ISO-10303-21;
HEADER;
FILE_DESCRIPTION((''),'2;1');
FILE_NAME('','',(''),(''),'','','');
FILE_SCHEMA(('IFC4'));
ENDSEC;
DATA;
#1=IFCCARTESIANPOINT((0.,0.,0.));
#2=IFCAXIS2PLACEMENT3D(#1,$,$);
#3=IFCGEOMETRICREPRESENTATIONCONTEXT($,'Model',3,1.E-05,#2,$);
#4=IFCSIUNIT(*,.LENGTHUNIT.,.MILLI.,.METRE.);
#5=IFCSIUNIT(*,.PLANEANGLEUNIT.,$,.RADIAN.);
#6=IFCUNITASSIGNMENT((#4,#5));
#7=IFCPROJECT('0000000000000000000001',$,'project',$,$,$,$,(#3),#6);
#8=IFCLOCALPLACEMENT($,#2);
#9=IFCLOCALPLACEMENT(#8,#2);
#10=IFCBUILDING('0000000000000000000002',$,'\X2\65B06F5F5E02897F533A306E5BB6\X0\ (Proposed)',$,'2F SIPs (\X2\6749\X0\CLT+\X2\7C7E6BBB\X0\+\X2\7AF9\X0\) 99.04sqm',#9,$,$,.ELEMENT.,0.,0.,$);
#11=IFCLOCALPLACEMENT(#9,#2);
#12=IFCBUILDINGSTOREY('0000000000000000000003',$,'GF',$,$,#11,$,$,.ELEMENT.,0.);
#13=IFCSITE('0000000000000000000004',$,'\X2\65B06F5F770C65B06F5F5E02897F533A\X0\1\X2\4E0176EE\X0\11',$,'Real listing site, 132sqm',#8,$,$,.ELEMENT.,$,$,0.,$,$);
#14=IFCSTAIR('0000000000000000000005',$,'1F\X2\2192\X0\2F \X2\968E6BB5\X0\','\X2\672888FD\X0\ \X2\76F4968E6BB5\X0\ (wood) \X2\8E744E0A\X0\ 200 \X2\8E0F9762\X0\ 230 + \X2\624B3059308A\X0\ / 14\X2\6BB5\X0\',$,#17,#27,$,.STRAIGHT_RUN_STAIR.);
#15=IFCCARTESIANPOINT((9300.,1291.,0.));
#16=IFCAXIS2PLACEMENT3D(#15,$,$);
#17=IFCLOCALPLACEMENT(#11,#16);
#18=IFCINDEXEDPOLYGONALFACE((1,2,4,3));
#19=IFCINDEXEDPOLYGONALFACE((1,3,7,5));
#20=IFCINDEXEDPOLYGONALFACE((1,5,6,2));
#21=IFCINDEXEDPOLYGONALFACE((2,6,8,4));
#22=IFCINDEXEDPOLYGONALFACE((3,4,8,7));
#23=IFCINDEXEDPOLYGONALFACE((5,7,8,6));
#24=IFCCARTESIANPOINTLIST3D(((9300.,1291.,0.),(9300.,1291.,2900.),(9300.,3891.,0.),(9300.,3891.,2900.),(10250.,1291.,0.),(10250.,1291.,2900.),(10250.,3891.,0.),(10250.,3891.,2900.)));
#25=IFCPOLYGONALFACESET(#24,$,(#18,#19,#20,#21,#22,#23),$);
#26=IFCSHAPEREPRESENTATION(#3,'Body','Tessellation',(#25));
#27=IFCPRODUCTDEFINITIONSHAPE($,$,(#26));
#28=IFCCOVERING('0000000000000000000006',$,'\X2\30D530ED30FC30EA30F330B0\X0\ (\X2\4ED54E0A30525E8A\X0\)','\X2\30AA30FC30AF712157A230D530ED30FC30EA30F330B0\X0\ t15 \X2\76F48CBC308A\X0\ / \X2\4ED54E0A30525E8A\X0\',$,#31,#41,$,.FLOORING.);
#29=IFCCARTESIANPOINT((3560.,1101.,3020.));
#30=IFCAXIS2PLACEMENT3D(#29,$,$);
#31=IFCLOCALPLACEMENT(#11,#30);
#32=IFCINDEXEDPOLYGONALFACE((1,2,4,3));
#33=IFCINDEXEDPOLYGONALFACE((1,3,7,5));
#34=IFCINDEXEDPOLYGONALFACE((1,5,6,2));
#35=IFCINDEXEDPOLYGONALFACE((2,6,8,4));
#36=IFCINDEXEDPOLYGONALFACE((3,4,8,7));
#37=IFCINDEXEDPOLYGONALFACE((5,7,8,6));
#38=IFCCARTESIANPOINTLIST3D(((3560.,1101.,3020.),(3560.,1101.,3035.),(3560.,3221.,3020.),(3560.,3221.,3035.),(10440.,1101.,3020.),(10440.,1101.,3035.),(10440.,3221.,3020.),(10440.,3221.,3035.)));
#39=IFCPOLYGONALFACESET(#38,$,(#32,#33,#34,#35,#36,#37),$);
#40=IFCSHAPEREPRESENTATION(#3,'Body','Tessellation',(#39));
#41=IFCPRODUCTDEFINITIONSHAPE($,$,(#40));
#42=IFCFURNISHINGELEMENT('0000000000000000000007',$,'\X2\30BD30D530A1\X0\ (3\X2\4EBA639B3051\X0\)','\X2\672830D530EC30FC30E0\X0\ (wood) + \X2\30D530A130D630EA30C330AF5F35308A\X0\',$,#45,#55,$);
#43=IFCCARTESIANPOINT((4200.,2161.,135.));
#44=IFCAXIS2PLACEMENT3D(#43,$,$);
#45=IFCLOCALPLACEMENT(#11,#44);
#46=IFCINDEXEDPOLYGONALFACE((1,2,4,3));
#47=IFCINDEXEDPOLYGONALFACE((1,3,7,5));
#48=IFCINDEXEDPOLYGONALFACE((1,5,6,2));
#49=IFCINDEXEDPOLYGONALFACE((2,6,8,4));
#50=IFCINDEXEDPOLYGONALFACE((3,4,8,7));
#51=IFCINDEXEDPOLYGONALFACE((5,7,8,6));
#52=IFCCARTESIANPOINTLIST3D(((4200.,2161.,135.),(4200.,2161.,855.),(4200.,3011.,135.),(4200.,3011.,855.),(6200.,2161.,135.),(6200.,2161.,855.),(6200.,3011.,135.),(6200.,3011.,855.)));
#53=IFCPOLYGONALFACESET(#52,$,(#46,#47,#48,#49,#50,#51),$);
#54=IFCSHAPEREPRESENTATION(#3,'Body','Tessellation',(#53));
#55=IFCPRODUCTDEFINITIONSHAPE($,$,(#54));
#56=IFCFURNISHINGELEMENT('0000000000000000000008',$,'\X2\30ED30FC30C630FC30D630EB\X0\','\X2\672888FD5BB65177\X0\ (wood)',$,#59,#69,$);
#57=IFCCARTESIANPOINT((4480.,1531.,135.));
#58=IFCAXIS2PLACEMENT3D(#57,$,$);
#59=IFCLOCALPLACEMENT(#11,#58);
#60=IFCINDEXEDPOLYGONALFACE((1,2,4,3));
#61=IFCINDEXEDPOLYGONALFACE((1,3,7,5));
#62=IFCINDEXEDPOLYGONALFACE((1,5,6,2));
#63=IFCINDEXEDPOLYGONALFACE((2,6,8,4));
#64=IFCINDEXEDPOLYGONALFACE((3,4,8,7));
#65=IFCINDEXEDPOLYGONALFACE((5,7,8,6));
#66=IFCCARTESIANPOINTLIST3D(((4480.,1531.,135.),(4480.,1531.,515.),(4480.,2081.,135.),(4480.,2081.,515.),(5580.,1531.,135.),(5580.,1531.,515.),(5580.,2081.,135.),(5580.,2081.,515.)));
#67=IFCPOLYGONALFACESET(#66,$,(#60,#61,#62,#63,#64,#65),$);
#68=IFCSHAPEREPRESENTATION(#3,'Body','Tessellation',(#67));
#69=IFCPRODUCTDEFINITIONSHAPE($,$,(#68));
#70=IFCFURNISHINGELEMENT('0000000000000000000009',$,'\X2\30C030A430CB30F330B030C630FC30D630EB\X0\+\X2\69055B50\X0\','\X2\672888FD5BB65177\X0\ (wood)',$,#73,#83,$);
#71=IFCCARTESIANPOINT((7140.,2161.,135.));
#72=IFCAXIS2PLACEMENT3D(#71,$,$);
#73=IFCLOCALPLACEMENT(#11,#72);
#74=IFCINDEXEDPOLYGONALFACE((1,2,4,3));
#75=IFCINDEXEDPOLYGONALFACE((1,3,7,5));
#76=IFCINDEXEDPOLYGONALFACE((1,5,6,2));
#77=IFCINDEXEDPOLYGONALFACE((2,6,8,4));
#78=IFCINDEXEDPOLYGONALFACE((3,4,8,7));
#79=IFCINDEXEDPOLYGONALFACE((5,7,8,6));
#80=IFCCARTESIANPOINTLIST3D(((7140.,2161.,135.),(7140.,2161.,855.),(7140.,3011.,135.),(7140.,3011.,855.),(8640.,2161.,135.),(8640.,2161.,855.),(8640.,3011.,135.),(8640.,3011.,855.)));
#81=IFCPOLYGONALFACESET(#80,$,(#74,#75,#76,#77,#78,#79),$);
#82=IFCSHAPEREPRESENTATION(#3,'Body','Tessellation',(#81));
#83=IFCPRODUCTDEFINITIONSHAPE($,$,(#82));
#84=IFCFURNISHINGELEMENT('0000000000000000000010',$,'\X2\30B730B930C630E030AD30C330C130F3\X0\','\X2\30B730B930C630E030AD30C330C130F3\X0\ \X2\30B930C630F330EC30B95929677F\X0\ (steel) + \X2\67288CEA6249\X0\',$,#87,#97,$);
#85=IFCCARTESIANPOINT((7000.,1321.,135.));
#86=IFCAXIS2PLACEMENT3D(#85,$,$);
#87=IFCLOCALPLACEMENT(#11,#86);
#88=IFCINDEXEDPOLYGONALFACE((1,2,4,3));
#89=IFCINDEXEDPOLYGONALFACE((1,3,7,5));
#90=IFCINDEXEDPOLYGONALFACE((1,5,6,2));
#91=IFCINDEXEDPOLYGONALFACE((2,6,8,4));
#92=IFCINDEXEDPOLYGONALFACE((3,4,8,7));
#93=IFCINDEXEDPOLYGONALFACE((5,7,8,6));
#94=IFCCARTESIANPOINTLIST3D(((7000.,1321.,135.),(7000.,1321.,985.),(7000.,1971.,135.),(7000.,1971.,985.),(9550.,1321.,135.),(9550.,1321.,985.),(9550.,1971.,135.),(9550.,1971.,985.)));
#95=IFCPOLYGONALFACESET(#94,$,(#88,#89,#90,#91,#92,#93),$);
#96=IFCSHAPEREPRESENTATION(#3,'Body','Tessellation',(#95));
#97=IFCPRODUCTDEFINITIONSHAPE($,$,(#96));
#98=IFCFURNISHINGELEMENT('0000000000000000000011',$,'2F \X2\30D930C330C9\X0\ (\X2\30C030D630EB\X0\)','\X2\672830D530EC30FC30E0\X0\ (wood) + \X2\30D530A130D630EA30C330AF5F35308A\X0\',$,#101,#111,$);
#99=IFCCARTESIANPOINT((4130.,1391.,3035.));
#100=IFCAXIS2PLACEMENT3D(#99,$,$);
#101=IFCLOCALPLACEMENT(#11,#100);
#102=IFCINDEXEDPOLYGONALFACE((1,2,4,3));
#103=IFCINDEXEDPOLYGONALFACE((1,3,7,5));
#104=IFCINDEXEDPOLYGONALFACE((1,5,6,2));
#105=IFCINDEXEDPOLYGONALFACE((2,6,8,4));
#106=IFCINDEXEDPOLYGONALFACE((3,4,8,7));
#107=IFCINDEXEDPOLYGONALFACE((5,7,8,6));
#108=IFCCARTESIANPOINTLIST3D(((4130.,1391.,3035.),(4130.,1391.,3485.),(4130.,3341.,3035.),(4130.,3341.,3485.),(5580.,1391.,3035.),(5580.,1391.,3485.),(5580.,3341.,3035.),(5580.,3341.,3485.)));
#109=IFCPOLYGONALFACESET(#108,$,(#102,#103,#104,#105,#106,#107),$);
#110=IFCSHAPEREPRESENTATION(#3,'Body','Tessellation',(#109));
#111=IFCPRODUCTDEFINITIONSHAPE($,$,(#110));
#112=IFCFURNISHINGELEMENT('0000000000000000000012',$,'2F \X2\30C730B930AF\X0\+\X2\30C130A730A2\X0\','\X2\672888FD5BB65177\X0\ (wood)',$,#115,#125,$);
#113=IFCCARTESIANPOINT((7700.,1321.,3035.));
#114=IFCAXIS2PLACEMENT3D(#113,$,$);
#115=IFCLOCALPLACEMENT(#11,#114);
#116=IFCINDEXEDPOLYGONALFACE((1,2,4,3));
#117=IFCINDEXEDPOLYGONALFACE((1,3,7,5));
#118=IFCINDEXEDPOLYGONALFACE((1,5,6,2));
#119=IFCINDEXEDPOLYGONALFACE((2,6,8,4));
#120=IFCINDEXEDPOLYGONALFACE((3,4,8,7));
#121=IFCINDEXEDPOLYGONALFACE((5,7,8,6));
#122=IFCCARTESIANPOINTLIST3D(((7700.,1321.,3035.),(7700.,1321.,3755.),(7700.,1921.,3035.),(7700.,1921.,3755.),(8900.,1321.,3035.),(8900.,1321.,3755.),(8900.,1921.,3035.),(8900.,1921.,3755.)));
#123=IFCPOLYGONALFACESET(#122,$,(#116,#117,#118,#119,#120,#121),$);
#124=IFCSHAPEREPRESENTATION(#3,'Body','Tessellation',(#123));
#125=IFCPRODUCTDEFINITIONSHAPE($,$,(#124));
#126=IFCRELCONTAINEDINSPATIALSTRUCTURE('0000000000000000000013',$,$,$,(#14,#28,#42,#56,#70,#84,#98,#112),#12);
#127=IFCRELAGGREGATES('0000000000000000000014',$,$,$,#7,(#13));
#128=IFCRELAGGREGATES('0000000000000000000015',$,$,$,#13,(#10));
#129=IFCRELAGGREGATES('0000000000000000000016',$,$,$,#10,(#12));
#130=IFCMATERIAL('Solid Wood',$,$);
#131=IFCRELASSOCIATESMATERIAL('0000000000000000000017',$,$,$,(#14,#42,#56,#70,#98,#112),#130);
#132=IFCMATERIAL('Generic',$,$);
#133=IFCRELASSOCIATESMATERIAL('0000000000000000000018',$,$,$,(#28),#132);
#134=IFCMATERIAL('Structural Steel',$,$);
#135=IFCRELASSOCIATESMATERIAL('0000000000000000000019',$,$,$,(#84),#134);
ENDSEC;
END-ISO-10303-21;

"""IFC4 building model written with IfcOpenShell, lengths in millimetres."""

from ifc_helpers import new_model, si_unit, frame, frame_2d, origin, place, context, project, spatial, rectangle, extrude, material, element, save


model = new_model("IFC4")

# Units and contexts
model_context = context("Model", 3, precision=1e-05, world=origin())
ifc_project = project(units=[si_unit("LENGTHUNIT", "METRE", prefix="MILLI"), si_unit("PLANEANGLEUNIT", "RADIAN")], contexts=[model_context])

# Site, building, storey
site_placement = place(None, origin())
site = spatial("IfcSite", under=ifc_project, at=site_placement, Name="新潟県新潟市西区1丁目11", ObjectType="Real listing site, 132sqm", CompositionType="ELEMENT", RefElevation=0.0)
building_placement = place(site_placement, origin())
building = spatial("IfcBuilding", under=site, at=building_placement, Name="新潟市西区の家 (Proposed)", ObjectType="2F SIPs (杉CLT+籾殻+竹) 99.04sqm", CompositionType="ELEMENT", ElevationOfRefHeight=0.0, ElevationOfTerrain=0.0)
storey_placement = place(building_placement, origin())
storey = spatial("IfcBuildingStorey", under=building, at=storey_placement, Name="GF", CompositionType="ELEMENT", Elevation=0.0)

# Shared definitions
ifc_material_1 = material(Name="Solid Wood")

# Shared definitions
ifc_material_2 = material(Name="Generic")

# Stair
stair_placement = place(storey_placement, frame((9300.0, 1291.0, 0.0)))
element("IfcStair", 1, at=stair_placement, inside=storey, material=ifc_material_1, Name="1F→2F 階段", Description="木製 直階段 (wood) 蹴上 200 踏面 230 + 手すり / 14段", PredefinedType="STRAIGHT_RUN_STAIR", context=model_context, shape_type="SweptSolid", body=[
    extrude(rectangle(XDim=950.0, YDim=2600.0, at=frame_2d((475.0, 1300.0))), frame((9300.0, 1291.0, 0.0)), (0.0, 0.0, 1.0), 2900.0),
])

# Covering
covering_placement = place(storey_placement, frame((3560.0, 1101.0, 3020.0)))
element("IfcCovering", 2, at=covering_placement, inside=storey, material=ifc_material_2, Name="フローリング (仕上げ床)", Description="オーク無垢フローリング t15 直貼り / 仕上げ床", PredefinedType="FLOORING", context=model_context, shape_type="SweptSolid", body=[
    extrude(rectangle(XDim=6880.0, YDim=2120.0, at=frame_2d((3440.0, 1060.0))), frame((3560.0, 1101.0, 3020.0)), (0.0, 0.0, 1.0), 15.0),
])

# Furnishing elements
furnishing_1_placement = place(storey_placement, frame((4200.0, 2161.0, 135.0)))
element("IfcFurnishingElement", 3, at=furnishing_1_placement, inside=storey, material=ifc_material_1, Name="ソファ (3人掛け)", Description="木フレーム (wood) + ファブリック張り", context=model_context, shape_type="SweptSolid", body=[
    extrude(rectangle(XDim=2000.0, YDim=850.0, at=frame_2d((1000.0, 425.0))), frame((4200.0, 2161.0, 135.0)), (0.0, 0.0, 1.0), 720.0),
])
furnishing_2_placement = place(storey_placement, frame((4480.0, 1531.0, 135.0)))
element("IfcFurnishingElement", 4, at=furnishing_2_placement, inside=storey, material=ifc_material_1, Name="ローテーブル", Description="木製家具 (wood)", context=model_context, shape_type="SweptSolid", body=[
    extrude(rectangle(XDim=1100.0, YDim=550.0, at=frame_2d((550.0, 275.0))), frame((4480.0, 1531.0, 135.0)), (0.0, 0.0, 1.0), 380.0),
])
furnishing_3_placement = place(storey_placement, frame((7140.0, 2161.0, 135.0)))
element("IfcFurnishingElement", 5, at=furnishing_3_placement, inside=storey, material=ifc_material_1, Name="ダイニングテーブル+椅子", Description="木製家具 (wood)", context=model_context, shape_type="SweptSolid", body=[
    extrude(rectangle(XDim=1500.0, YDim=850.0, at=frame_2d((750.0, 425.0))), frame((7140.0, 2161.0, 135.0)), (0.0, 0.0, 1.0), 720.0),
])
ifc_material_3 = material(Name="Structural Steel")
furnishing_4_placement = place(storey_placement, frame((7000.0, 1321.0, 135.0)))
element("IfcFurnishingElement", 6, at=furnishing_4_placement, inside=storey, material=ifc_material_3, Name="システムキッチン", Description="システムキッチン ステンレス天板 (steel) + 木質扉", context=model_context, shape_type="SweptSolid", body=[
    extrude(rectangle(XDim=2550.0, YDim=650.0, at=frame_2d((1275.0, 325.0))), frame((7000.0, 1321.0, 135.0)), (0.0, 0.0, 1.0), 850.0),
])
furnishing_5_placement = place(storey_placement, frame((4130.0, 1391.0, 3035.0)))
element("IfcFurnishingElement", 7, at=furnishing_5_placement, inside=storey, material=ifc_material_1, Name="2F ベッド (ダブル)", Description="木フレーム (wood) + ファブリック張り", context=model_context, shape_type="SweptSolid", body=[
    extrude(rectangle(XDim=1450.0, YDim=1950.0, at=frame_2d((725.0, 975.0))), frame((4130.0, 1391.0, 3035.0)), (0.0, 0.0, 1.0), 450.0),
])
furnishing_6_placement = place(storey_placement, frame((7700.0, 1321.0, 3035.0)))
element("IfcFurnishingElement", 8, at=furnishing_6_placement, inside=storey, material=ifc_material_1, Name="2F デスク+チェア", Description="木製家具 (wood)", context=model_context, shape_type="SweptSolid", body=[
    extrude(rectangle(XDim=1200.0, YDim=600.0, at=frame_2d((600.0, 300.0))), frame((7700.0, 1321.0, 3035.0)), (0.0, 0.0, 1.0), 720.0),
])

save(model, "model.ifc")
